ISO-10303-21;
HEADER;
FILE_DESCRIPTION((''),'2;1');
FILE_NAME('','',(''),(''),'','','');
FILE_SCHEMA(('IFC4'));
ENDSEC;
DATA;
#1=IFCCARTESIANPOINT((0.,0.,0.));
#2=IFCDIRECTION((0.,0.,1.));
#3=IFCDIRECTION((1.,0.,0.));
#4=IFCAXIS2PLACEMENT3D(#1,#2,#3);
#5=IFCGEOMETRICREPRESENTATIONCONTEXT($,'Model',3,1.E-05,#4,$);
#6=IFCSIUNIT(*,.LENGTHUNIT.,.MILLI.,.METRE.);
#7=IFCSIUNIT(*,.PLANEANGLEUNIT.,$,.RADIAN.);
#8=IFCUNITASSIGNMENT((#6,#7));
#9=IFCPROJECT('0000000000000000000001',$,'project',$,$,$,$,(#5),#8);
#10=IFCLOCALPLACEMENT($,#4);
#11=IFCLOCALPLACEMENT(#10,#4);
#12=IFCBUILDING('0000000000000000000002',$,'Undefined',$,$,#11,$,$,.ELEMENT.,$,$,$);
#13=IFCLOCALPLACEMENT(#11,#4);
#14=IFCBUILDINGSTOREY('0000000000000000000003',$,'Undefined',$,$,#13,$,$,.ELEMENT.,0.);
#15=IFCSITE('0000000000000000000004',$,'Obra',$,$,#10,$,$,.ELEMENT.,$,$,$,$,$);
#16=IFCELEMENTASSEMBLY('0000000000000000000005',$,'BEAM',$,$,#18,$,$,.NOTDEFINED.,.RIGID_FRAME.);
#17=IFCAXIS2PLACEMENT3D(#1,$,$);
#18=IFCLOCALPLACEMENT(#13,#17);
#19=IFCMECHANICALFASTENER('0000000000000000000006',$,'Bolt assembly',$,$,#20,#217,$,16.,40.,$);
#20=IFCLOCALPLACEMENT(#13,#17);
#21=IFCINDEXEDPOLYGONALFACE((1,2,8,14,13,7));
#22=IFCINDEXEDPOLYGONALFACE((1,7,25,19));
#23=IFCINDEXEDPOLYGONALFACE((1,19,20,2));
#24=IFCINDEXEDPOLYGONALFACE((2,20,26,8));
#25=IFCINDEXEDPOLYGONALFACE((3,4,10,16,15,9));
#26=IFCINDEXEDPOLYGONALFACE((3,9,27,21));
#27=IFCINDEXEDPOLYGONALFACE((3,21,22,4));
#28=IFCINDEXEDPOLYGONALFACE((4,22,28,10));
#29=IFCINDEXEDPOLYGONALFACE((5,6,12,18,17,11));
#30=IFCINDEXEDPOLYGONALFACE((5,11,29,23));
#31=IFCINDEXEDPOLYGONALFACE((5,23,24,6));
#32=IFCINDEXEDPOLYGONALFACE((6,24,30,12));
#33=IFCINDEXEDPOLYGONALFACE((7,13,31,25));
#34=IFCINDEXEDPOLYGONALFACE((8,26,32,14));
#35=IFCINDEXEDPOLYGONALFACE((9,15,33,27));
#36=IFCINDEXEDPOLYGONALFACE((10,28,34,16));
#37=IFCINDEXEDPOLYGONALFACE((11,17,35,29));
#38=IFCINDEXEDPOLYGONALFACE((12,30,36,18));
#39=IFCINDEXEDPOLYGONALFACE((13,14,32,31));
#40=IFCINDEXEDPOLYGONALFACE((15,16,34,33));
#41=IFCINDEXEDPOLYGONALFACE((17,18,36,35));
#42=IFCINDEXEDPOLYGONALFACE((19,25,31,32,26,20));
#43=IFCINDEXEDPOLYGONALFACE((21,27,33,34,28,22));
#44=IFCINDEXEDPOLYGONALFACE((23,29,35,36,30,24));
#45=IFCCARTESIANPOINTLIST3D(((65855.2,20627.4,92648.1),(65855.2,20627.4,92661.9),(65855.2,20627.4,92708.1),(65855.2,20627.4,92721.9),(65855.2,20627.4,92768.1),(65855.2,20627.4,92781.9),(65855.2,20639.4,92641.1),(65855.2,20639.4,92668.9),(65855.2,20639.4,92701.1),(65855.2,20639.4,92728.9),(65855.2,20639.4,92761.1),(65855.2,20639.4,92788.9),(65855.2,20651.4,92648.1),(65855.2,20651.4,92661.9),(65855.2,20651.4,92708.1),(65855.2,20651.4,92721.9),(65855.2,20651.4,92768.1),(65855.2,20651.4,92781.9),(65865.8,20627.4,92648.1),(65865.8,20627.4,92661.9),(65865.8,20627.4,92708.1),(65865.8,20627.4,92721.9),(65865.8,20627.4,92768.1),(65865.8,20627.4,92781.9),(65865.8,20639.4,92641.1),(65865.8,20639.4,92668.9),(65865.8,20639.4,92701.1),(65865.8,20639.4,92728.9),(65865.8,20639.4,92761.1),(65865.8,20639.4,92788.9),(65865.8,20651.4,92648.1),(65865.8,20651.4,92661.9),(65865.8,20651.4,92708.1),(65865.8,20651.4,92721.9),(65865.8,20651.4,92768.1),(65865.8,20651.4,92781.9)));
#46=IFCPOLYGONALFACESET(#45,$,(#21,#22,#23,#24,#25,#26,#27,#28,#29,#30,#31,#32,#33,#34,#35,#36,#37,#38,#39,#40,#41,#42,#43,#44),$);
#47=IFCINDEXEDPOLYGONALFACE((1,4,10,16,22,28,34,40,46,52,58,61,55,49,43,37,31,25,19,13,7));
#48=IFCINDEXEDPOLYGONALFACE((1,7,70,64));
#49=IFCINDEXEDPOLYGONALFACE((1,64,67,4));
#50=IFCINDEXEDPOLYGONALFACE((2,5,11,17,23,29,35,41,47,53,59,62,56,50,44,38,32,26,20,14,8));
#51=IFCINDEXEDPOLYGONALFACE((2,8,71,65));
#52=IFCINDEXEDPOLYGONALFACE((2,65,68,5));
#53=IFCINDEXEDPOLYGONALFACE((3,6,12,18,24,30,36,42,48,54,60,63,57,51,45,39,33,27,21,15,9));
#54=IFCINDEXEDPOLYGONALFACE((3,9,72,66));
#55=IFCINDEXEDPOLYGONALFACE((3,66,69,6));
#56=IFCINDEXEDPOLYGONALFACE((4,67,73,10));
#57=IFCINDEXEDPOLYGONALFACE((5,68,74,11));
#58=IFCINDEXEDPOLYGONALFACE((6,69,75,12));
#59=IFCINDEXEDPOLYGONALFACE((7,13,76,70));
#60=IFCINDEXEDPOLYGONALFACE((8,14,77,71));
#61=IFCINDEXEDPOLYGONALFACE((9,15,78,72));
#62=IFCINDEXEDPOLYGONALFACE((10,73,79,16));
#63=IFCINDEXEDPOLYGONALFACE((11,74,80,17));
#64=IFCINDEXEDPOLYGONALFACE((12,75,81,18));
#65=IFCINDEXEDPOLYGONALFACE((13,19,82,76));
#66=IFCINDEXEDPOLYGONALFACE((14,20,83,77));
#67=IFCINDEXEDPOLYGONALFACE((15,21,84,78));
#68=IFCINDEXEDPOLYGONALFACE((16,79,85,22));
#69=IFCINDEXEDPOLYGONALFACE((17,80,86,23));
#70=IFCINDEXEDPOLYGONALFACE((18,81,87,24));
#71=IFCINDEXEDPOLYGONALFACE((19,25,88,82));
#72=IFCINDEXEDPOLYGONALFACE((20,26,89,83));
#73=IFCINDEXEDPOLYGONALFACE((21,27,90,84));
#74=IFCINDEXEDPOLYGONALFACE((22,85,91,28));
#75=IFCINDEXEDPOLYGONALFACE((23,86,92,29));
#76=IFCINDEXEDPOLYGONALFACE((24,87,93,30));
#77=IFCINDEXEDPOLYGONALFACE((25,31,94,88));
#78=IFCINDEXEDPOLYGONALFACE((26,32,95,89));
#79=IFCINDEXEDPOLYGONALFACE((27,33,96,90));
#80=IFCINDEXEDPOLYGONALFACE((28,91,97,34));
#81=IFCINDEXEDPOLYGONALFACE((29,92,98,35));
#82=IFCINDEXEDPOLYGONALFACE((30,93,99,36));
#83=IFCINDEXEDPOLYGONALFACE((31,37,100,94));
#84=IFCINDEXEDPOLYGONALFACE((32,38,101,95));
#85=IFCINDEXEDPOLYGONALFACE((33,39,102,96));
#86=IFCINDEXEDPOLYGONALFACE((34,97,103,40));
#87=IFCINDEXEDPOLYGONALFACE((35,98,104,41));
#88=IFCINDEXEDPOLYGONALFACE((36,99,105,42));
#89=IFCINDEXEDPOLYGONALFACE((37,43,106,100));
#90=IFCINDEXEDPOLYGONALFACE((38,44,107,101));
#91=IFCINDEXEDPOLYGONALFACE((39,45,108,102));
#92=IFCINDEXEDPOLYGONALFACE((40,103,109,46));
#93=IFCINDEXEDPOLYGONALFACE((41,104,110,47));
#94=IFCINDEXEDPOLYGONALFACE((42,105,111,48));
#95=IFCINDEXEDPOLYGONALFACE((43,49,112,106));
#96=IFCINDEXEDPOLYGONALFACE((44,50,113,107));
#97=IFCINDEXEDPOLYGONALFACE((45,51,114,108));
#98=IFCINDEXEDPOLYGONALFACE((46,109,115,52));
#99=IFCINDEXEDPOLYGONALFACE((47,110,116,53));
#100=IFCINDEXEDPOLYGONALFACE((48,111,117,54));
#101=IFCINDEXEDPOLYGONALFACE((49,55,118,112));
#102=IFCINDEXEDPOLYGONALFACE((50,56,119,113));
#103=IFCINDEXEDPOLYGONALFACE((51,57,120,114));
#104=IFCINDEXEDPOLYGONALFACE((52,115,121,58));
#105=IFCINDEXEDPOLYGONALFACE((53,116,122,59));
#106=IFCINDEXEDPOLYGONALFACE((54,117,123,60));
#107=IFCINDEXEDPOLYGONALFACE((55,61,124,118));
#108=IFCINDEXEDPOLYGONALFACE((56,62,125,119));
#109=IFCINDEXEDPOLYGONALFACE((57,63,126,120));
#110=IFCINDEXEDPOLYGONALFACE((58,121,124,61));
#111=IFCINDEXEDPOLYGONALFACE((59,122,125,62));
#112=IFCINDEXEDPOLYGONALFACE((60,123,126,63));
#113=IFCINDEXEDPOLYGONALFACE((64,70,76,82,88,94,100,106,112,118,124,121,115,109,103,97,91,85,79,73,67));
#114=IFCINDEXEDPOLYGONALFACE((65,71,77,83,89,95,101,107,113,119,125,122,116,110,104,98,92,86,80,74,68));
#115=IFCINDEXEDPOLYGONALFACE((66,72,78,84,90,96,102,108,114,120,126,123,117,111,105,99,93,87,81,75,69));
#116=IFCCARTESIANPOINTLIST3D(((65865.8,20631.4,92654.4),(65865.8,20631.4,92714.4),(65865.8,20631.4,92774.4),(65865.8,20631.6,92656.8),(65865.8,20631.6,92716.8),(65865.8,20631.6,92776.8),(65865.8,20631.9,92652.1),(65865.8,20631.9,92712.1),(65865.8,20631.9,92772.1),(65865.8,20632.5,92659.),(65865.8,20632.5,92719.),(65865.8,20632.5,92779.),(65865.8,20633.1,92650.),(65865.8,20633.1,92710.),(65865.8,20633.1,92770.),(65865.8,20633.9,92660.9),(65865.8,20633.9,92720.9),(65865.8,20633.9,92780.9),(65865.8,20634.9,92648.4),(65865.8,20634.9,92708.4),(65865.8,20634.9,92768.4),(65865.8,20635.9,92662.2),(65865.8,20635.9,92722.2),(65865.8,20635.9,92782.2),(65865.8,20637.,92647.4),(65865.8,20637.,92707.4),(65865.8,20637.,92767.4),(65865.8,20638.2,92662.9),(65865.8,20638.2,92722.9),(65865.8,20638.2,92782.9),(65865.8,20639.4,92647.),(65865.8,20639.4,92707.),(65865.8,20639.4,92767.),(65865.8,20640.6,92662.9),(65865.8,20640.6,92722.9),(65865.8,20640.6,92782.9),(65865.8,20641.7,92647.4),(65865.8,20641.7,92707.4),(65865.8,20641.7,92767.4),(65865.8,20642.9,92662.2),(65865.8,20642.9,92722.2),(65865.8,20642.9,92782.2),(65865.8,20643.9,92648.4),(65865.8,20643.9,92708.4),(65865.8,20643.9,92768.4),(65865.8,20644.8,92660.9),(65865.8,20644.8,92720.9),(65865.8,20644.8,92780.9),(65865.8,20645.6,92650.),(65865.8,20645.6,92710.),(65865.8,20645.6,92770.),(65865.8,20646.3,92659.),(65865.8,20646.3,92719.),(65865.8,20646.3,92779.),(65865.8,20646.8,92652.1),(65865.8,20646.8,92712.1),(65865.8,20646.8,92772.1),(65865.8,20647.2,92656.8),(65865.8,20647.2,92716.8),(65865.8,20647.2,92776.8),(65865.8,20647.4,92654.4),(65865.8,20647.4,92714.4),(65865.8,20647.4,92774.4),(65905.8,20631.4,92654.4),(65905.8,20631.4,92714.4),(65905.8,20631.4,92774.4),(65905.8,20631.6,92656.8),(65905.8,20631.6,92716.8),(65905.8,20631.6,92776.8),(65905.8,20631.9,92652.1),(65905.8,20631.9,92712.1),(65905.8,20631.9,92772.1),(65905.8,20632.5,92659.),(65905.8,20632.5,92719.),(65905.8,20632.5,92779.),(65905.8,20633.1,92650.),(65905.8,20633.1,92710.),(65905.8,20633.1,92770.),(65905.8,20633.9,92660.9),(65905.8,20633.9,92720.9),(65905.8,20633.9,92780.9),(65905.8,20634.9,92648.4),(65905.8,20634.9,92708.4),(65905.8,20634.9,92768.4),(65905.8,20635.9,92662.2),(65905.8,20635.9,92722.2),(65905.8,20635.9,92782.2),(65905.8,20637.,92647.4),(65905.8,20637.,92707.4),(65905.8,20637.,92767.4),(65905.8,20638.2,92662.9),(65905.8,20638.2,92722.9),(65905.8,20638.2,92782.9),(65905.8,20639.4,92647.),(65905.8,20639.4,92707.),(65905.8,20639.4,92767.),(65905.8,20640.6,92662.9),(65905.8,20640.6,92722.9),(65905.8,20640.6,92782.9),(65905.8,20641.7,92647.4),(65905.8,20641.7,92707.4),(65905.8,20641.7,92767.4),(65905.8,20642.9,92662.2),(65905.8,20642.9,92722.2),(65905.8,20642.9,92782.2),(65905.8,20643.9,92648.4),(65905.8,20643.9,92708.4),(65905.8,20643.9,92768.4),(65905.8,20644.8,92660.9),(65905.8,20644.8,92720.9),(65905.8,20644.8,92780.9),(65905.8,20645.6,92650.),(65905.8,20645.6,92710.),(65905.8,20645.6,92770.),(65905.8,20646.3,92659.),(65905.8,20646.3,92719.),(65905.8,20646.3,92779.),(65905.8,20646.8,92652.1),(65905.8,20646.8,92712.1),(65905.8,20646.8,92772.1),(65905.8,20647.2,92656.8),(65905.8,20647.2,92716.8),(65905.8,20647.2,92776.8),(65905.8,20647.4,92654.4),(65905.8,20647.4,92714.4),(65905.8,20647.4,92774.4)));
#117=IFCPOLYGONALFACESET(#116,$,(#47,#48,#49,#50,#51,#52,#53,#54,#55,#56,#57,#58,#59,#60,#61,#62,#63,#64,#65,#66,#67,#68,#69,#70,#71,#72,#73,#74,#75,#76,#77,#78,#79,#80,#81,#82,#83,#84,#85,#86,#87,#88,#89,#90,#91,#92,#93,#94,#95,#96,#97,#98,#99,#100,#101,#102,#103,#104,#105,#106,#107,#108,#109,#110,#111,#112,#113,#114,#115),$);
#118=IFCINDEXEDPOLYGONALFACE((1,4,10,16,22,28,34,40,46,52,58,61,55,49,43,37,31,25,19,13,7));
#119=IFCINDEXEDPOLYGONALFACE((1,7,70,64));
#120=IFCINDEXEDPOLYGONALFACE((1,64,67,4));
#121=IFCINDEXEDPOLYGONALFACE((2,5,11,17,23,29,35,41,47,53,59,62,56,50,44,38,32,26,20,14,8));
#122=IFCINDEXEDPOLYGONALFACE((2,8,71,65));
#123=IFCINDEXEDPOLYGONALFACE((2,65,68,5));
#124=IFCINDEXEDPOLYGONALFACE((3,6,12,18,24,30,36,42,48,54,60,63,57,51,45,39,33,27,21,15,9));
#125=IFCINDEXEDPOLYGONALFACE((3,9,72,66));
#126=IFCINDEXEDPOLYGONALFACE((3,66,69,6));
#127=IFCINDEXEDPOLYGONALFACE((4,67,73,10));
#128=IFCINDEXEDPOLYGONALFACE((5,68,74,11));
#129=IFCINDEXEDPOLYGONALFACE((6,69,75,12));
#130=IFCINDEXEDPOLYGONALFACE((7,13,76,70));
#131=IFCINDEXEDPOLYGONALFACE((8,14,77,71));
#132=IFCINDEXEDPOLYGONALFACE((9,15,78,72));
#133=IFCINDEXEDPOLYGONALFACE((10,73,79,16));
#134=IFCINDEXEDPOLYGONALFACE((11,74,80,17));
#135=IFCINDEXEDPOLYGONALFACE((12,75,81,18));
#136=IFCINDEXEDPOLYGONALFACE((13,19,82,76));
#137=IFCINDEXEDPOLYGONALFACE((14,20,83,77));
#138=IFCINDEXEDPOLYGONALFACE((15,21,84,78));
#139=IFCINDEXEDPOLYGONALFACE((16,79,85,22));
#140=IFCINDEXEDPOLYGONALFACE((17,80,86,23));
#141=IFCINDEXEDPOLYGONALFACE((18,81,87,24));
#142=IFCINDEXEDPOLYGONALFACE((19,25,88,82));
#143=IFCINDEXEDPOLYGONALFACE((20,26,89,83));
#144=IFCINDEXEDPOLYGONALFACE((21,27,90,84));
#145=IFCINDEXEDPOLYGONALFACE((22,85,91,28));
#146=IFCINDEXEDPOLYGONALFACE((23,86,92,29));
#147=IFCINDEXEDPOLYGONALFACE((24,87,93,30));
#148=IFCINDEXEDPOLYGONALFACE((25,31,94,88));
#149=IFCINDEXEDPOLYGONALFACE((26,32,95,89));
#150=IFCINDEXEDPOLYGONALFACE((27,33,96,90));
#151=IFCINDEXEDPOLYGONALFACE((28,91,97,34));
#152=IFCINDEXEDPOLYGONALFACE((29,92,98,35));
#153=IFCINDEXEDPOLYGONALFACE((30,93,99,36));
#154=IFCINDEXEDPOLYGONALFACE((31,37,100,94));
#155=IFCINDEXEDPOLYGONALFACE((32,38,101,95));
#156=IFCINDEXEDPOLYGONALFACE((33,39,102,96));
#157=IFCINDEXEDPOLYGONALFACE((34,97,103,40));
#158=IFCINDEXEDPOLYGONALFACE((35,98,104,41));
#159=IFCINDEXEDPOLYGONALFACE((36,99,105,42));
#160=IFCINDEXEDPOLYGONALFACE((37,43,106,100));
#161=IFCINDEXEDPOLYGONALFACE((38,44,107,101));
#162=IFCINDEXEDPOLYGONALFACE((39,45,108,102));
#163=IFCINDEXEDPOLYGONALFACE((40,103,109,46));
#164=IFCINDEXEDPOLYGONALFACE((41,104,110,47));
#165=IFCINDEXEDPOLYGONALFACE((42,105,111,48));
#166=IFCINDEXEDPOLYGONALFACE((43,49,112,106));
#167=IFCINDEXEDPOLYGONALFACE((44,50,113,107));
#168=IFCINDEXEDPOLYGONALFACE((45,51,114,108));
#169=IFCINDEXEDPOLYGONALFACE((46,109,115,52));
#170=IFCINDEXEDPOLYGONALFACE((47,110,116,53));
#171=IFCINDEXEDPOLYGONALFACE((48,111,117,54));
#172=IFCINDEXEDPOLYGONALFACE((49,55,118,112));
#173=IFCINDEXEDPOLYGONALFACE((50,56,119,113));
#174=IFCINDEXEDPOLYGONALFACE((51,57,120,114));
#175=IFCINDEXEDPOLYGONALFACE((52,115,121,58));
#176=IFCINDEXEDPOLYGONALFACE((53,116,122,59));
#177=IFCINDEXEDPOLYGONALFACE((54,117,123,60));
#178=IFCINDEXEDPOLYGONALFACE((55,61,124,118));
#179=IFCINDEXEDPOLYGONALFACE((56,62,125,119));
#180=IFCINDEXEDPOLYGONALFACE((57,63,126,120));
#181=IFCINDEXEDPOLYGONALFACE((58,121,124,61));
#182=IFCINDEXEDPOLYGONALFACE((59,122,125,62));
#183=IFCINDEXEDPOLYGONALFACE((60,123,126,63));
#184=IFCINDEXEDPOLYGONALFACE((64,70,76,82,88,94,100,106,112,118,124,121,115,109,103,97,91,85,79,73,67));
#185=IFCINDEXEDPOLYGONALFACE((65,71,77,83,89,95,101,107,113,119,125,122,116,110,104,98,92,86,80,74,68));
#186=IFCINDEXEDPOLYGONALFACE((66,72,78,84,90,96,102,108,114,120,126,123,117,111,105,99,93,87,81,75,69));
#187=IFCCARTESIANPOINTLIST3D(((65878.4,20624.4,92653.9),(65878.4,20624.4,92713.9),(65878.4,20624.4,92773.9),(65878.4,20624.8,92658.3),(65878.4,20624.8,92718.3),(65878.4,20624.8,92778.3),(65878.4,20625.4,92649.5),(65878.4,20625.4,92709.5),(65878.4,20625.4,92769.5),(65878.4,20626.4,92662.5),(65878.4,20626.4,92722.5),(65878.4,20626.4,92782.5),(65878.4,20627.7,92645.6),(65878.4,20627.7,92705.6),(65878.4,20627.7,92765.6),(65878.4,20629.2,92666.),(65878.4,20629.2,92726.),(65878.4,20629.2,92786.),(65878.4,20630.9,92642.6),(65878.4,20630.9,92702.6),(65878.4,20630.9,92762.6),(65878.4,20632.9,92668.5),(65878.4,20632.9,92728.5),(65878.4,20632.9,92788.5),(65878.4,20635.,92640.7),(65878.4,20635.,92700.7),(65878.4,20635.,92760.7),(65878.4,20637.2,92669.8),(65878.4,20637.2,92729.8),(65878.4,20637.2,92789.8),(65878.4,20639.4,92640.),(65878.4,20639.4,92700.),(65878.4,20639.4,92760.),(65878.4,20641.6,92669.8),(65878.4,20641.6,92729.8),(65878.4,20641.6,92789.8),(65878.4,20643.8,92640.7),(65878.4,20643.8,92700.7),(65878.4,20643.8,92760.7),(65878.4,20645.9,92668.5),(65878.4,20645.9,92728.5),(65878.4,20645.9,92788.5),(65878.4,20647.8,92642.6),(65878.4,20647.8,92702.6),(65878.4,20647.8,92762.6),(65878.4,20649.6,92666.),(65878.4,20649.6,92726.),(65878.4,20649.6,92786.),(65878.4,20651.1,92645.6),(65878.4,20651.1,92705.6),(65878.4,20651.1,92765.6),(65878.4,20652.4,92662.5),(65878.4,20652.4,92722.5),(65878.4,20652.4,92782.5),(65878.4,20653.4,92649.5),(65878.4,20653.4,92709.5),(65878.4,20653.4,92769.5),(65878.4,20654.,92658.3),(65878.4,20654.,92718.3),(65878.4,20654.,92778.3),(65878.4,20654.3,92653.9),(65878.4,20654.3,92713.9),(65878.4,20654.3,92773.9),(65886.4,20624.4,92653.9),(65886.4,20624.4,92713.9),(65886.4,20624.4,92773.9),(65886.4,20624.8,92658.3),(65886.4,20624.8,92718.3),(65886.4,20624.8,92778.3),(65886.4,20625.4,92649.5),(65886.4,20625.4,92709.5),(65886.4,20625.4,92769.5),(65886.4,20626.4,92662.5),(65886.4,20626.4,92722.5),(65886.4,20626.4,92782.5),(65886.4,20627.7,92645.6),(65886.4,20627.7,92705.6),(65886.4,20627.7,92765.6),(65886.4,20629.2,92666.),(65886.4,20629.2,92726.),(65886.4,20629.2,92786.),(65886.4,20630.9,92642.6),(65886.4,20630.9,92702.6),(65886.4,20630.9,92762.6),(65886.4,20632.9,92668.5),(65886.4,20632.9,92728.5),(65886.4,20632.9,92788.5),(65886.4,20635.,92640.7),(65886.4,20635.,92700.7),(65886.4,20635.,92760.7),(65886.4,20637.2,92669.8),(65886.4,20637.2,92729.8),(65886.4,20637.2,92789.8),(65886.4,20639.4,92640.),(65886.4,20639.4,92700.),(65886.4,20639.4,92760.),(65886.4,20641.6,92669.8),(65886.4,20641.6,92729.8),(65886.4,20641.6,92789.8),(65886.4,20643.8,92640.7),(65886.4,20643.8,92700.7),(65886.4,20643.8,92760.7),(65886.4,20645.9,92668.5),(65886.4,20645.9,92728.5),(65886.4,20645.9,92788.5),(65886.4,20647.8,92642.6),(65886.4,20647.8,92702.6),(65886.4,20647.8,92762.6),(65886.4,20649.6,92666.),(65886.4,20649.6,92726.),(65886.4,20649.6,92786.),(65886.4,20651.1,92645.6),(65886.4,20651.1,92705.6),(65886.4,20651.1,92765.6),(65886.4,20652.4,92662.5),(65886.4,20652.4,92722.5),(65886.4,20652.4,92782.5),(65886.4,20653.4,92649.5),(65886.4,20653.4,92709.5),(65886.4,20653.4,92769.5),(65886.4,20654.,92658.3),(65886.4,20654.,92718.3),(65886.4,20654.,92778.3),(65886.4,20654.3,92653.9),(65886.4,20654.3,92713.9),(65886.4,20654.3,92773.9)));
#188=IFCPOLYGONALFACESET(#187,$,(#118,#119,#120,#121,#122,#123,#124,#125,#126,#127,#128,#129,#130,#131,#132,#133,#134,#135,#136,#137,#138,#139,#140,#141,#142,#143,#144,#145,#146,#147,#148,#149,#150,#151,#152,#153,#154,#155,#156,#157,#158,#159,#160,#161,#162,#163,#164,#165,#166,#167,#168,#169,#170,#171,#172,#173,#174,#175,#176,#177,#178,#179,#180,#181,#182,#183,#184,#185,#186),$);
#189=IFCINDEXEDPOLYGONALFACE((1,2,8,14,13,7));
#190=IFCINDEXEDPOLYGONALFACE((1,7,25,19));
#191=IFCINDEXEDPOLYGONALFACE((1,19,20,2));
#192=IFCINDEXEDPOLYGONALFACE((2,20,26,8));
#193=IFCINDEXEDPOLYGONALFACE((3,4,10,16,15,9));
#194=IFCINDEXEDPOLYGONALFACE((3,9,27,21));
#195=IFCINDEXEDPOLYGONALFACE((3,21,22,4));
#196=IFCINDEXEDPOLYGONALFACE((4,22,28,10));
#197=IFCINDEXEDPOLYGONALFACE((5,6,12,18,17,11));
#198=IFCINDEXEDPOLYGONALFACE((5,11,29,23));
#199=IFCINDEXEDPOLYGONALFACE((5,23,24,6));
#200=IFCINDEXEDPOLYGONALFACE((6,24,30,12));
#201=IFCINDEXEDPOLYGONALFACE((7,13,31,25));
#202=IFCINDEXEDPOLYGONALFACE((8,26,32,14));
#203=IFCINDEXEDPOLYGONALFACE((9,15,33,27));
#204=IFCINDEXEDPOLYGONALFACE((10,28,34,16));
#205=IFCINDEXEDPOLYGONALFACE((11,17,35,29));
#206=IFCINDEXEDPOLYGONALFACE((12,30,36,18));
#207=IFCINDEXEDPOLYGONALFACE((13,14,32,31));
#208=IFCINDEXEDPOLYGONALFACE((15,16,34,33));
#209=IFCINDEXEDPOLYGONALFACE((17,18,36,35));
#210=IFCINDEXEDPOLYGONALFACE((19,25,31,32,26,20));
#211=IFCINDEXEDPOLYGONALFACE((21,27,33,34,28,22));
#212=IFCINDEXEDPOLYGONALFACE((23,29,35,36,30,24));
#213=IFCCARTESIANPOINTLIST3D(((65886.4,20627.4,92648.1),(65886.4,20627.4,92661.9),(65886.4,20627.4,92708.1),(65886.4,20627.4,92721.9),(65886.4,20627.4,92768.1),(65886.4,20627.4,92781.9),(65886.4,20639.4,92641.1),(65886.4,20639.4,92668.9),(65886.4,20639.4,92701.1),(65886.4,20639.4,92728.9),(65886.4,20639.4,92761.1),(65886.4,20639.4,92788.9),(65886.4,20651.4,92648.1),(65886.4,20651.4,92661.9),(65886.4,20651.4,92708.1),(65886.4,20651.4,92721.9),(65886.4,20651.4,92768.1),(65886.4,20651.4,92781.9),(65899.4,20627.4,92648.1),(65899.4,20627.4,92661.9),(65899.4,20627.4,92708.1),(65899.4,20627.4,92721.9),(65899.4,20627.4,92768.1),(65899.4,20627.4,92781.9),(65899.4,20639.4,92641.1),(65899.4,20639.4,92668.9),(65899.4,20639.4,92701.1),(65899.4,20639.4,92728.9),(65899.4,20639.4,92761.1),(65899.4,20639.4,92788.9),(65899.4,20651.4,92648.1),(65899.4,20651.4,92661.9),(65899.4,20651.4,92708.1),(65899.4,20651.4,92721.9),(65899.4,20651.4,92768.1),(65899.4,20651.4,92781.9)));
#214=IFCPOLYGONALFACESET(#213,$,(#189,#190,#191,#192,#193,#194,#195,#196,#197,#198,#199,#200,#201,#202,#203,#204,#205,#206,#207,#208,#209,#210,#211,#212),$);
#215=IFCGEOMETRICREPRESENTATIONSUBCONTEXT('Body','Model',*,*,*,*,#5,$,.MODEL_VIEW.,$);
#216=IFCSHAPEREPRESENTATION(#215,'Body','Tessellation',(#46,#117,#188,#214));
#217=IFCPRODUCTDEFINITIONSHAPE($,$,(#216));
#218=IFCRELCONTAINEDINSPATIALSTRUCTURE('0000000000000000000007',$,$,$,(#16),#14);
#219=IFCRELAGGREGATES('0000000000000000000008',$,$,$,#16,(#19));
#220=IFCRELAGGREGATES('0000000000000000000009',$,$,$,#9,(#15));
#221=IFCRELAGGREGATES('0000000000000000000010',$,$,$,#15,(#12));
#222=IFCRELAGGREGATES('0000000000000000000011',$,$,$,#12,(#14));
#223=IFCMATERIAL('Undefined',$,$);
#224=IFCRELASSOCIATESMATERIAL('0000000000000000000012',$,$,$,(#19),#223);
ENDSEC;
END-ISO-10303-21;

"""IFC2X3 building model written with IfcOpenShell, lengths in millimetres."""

from ifc_helpers import new_model, si_unit, frame, origin_with_axes, origin_2d_with_axis, place, context, subcontext, project, spatial, polyline, circle, outline, extrude, source, transform, mapped, material, element, aggregate, save


model = new_model("IFC2X3")

# Units and contexts
model_context = context("Model", 3, precision=1e-05, world=origin_with_axes())
body_context = subcontext(model_context, "Body", "Model", "MODEL_VIEW")
ifc_project = project(units=[si_unit("LENGTHUNIT", "METRE", prefix="MILLI"), si_unit("PLANEANGLEUNIT", "RADIAN")], contexts=[model_context])

# Site, building, storey
site_placement = place(None, origin_with_axes())
site = spatial("IfcSite", under=ifc_project, at=site_placement, Name="Obra", CompositionType="ELEMENT")
building_placement = place(site_placement, origin_with_axes())
building = spatial("IfcBuilding", under=site, at=building_placement, Name="Undefined", CompositionType="ELEMENT")
storey_placement = place(building_placement, origin_with_axes())
storey = spatial("IfcBuildingStorey", under=building, at=storey_placement, Name="Undefined", CompositionType="ELEMENT", Elevation=0.0)

# Shared definitions
ifc_material_1 = material(Name="Undefined")

# Element assembly
assembly_1_placement = place(storey_placement, origin_with_axes())
assembly_1 = element("IfcElementAssembly", 1, at=assembly_1_placement, inside=storey, Name="BEAM", AssemblyPlace="NOTDEFINED", PredefinedType="RIGID_FRAME")

# Mechanical fastener
shared_shape_1 = source(origin_with_axes(), body_context, "Body", "SweptSolid", [
    extrude(outline(polyline([(13.9, 0.0), (6.9, 12.0), (-6.9, 12.0), (-13.9, 0.0), (-6.9, -12.0), (6.9, -12.0), (13.9, 0.0)])), frame((0.0, -19.9, 0.0), z_axis=(0.0, 1.0, 0.0), x_axis=(1.0, 0.0, 0.0)), (0.0, 0.0, 1.0), 10.6),
    extrude(circle(Radius=8.0, at=origin_2d_with_axis()), frame((0.0, -9.3, 0.0), z_axis=(0.0, 1.0, 0.0), x_axis=(1.0, 0.0, 0.0)), (0.0, 0.0, 1.0), 40.0),
    extrude(circle(Radius=15.0, at=origin_2d_with_axis()), frame((0.0, 3.3, 0.0), z_axis=(0.0, 1.0, 0.0), x_axis=(1.0, 0.0, 0.0)), (0.0, 0.0, 1.0), 8.0),
    extrude(outline(polyline([(13.9, 0.0), (6.9, 12.0), (-6.9, 12.0), (-13.9, 0.0), (-6.9, -12.0), (6.9, -12.0), (13.9, 0.0)])), frame((0.0, 11.3, 0.0), z_axis=(0.0, 1.0, 0.0), x_axis=(1.0, 0.0, 0.0)), (0.0, 0.0, 1.0), 13.0),
])
mechanical_fastener_1_placement = place(assembly_1_placement, frame((65875.1, 20689.4, 92850.0), z_axis=(0.000002, -1.0, 0.0), x_axis=(0.0, 0.0, -1.0)))
mechanical_fastener_1 = element("IfcMechanicalFastener", 2, at=mechanical_fastener_1_placement, material=ifc_material_1, Name="Bolt assembly", NominalDiameter=16.0, NominalLength=40.0, context=body_context, shape_type="MappedRepresentation", body=[
    mapped(shared_shape_1, transform((75.0, 0.0, 50.0))),
    mapped(shared_shape_1, transform((135.0, 0.0, 50.0))),
    mapped(shared_shape_1, transform((195.0, 0.0, 50.0))),
])
aggregate(assembly_1, [mechanical_fastener_1])

save(model, "model.ifc")
